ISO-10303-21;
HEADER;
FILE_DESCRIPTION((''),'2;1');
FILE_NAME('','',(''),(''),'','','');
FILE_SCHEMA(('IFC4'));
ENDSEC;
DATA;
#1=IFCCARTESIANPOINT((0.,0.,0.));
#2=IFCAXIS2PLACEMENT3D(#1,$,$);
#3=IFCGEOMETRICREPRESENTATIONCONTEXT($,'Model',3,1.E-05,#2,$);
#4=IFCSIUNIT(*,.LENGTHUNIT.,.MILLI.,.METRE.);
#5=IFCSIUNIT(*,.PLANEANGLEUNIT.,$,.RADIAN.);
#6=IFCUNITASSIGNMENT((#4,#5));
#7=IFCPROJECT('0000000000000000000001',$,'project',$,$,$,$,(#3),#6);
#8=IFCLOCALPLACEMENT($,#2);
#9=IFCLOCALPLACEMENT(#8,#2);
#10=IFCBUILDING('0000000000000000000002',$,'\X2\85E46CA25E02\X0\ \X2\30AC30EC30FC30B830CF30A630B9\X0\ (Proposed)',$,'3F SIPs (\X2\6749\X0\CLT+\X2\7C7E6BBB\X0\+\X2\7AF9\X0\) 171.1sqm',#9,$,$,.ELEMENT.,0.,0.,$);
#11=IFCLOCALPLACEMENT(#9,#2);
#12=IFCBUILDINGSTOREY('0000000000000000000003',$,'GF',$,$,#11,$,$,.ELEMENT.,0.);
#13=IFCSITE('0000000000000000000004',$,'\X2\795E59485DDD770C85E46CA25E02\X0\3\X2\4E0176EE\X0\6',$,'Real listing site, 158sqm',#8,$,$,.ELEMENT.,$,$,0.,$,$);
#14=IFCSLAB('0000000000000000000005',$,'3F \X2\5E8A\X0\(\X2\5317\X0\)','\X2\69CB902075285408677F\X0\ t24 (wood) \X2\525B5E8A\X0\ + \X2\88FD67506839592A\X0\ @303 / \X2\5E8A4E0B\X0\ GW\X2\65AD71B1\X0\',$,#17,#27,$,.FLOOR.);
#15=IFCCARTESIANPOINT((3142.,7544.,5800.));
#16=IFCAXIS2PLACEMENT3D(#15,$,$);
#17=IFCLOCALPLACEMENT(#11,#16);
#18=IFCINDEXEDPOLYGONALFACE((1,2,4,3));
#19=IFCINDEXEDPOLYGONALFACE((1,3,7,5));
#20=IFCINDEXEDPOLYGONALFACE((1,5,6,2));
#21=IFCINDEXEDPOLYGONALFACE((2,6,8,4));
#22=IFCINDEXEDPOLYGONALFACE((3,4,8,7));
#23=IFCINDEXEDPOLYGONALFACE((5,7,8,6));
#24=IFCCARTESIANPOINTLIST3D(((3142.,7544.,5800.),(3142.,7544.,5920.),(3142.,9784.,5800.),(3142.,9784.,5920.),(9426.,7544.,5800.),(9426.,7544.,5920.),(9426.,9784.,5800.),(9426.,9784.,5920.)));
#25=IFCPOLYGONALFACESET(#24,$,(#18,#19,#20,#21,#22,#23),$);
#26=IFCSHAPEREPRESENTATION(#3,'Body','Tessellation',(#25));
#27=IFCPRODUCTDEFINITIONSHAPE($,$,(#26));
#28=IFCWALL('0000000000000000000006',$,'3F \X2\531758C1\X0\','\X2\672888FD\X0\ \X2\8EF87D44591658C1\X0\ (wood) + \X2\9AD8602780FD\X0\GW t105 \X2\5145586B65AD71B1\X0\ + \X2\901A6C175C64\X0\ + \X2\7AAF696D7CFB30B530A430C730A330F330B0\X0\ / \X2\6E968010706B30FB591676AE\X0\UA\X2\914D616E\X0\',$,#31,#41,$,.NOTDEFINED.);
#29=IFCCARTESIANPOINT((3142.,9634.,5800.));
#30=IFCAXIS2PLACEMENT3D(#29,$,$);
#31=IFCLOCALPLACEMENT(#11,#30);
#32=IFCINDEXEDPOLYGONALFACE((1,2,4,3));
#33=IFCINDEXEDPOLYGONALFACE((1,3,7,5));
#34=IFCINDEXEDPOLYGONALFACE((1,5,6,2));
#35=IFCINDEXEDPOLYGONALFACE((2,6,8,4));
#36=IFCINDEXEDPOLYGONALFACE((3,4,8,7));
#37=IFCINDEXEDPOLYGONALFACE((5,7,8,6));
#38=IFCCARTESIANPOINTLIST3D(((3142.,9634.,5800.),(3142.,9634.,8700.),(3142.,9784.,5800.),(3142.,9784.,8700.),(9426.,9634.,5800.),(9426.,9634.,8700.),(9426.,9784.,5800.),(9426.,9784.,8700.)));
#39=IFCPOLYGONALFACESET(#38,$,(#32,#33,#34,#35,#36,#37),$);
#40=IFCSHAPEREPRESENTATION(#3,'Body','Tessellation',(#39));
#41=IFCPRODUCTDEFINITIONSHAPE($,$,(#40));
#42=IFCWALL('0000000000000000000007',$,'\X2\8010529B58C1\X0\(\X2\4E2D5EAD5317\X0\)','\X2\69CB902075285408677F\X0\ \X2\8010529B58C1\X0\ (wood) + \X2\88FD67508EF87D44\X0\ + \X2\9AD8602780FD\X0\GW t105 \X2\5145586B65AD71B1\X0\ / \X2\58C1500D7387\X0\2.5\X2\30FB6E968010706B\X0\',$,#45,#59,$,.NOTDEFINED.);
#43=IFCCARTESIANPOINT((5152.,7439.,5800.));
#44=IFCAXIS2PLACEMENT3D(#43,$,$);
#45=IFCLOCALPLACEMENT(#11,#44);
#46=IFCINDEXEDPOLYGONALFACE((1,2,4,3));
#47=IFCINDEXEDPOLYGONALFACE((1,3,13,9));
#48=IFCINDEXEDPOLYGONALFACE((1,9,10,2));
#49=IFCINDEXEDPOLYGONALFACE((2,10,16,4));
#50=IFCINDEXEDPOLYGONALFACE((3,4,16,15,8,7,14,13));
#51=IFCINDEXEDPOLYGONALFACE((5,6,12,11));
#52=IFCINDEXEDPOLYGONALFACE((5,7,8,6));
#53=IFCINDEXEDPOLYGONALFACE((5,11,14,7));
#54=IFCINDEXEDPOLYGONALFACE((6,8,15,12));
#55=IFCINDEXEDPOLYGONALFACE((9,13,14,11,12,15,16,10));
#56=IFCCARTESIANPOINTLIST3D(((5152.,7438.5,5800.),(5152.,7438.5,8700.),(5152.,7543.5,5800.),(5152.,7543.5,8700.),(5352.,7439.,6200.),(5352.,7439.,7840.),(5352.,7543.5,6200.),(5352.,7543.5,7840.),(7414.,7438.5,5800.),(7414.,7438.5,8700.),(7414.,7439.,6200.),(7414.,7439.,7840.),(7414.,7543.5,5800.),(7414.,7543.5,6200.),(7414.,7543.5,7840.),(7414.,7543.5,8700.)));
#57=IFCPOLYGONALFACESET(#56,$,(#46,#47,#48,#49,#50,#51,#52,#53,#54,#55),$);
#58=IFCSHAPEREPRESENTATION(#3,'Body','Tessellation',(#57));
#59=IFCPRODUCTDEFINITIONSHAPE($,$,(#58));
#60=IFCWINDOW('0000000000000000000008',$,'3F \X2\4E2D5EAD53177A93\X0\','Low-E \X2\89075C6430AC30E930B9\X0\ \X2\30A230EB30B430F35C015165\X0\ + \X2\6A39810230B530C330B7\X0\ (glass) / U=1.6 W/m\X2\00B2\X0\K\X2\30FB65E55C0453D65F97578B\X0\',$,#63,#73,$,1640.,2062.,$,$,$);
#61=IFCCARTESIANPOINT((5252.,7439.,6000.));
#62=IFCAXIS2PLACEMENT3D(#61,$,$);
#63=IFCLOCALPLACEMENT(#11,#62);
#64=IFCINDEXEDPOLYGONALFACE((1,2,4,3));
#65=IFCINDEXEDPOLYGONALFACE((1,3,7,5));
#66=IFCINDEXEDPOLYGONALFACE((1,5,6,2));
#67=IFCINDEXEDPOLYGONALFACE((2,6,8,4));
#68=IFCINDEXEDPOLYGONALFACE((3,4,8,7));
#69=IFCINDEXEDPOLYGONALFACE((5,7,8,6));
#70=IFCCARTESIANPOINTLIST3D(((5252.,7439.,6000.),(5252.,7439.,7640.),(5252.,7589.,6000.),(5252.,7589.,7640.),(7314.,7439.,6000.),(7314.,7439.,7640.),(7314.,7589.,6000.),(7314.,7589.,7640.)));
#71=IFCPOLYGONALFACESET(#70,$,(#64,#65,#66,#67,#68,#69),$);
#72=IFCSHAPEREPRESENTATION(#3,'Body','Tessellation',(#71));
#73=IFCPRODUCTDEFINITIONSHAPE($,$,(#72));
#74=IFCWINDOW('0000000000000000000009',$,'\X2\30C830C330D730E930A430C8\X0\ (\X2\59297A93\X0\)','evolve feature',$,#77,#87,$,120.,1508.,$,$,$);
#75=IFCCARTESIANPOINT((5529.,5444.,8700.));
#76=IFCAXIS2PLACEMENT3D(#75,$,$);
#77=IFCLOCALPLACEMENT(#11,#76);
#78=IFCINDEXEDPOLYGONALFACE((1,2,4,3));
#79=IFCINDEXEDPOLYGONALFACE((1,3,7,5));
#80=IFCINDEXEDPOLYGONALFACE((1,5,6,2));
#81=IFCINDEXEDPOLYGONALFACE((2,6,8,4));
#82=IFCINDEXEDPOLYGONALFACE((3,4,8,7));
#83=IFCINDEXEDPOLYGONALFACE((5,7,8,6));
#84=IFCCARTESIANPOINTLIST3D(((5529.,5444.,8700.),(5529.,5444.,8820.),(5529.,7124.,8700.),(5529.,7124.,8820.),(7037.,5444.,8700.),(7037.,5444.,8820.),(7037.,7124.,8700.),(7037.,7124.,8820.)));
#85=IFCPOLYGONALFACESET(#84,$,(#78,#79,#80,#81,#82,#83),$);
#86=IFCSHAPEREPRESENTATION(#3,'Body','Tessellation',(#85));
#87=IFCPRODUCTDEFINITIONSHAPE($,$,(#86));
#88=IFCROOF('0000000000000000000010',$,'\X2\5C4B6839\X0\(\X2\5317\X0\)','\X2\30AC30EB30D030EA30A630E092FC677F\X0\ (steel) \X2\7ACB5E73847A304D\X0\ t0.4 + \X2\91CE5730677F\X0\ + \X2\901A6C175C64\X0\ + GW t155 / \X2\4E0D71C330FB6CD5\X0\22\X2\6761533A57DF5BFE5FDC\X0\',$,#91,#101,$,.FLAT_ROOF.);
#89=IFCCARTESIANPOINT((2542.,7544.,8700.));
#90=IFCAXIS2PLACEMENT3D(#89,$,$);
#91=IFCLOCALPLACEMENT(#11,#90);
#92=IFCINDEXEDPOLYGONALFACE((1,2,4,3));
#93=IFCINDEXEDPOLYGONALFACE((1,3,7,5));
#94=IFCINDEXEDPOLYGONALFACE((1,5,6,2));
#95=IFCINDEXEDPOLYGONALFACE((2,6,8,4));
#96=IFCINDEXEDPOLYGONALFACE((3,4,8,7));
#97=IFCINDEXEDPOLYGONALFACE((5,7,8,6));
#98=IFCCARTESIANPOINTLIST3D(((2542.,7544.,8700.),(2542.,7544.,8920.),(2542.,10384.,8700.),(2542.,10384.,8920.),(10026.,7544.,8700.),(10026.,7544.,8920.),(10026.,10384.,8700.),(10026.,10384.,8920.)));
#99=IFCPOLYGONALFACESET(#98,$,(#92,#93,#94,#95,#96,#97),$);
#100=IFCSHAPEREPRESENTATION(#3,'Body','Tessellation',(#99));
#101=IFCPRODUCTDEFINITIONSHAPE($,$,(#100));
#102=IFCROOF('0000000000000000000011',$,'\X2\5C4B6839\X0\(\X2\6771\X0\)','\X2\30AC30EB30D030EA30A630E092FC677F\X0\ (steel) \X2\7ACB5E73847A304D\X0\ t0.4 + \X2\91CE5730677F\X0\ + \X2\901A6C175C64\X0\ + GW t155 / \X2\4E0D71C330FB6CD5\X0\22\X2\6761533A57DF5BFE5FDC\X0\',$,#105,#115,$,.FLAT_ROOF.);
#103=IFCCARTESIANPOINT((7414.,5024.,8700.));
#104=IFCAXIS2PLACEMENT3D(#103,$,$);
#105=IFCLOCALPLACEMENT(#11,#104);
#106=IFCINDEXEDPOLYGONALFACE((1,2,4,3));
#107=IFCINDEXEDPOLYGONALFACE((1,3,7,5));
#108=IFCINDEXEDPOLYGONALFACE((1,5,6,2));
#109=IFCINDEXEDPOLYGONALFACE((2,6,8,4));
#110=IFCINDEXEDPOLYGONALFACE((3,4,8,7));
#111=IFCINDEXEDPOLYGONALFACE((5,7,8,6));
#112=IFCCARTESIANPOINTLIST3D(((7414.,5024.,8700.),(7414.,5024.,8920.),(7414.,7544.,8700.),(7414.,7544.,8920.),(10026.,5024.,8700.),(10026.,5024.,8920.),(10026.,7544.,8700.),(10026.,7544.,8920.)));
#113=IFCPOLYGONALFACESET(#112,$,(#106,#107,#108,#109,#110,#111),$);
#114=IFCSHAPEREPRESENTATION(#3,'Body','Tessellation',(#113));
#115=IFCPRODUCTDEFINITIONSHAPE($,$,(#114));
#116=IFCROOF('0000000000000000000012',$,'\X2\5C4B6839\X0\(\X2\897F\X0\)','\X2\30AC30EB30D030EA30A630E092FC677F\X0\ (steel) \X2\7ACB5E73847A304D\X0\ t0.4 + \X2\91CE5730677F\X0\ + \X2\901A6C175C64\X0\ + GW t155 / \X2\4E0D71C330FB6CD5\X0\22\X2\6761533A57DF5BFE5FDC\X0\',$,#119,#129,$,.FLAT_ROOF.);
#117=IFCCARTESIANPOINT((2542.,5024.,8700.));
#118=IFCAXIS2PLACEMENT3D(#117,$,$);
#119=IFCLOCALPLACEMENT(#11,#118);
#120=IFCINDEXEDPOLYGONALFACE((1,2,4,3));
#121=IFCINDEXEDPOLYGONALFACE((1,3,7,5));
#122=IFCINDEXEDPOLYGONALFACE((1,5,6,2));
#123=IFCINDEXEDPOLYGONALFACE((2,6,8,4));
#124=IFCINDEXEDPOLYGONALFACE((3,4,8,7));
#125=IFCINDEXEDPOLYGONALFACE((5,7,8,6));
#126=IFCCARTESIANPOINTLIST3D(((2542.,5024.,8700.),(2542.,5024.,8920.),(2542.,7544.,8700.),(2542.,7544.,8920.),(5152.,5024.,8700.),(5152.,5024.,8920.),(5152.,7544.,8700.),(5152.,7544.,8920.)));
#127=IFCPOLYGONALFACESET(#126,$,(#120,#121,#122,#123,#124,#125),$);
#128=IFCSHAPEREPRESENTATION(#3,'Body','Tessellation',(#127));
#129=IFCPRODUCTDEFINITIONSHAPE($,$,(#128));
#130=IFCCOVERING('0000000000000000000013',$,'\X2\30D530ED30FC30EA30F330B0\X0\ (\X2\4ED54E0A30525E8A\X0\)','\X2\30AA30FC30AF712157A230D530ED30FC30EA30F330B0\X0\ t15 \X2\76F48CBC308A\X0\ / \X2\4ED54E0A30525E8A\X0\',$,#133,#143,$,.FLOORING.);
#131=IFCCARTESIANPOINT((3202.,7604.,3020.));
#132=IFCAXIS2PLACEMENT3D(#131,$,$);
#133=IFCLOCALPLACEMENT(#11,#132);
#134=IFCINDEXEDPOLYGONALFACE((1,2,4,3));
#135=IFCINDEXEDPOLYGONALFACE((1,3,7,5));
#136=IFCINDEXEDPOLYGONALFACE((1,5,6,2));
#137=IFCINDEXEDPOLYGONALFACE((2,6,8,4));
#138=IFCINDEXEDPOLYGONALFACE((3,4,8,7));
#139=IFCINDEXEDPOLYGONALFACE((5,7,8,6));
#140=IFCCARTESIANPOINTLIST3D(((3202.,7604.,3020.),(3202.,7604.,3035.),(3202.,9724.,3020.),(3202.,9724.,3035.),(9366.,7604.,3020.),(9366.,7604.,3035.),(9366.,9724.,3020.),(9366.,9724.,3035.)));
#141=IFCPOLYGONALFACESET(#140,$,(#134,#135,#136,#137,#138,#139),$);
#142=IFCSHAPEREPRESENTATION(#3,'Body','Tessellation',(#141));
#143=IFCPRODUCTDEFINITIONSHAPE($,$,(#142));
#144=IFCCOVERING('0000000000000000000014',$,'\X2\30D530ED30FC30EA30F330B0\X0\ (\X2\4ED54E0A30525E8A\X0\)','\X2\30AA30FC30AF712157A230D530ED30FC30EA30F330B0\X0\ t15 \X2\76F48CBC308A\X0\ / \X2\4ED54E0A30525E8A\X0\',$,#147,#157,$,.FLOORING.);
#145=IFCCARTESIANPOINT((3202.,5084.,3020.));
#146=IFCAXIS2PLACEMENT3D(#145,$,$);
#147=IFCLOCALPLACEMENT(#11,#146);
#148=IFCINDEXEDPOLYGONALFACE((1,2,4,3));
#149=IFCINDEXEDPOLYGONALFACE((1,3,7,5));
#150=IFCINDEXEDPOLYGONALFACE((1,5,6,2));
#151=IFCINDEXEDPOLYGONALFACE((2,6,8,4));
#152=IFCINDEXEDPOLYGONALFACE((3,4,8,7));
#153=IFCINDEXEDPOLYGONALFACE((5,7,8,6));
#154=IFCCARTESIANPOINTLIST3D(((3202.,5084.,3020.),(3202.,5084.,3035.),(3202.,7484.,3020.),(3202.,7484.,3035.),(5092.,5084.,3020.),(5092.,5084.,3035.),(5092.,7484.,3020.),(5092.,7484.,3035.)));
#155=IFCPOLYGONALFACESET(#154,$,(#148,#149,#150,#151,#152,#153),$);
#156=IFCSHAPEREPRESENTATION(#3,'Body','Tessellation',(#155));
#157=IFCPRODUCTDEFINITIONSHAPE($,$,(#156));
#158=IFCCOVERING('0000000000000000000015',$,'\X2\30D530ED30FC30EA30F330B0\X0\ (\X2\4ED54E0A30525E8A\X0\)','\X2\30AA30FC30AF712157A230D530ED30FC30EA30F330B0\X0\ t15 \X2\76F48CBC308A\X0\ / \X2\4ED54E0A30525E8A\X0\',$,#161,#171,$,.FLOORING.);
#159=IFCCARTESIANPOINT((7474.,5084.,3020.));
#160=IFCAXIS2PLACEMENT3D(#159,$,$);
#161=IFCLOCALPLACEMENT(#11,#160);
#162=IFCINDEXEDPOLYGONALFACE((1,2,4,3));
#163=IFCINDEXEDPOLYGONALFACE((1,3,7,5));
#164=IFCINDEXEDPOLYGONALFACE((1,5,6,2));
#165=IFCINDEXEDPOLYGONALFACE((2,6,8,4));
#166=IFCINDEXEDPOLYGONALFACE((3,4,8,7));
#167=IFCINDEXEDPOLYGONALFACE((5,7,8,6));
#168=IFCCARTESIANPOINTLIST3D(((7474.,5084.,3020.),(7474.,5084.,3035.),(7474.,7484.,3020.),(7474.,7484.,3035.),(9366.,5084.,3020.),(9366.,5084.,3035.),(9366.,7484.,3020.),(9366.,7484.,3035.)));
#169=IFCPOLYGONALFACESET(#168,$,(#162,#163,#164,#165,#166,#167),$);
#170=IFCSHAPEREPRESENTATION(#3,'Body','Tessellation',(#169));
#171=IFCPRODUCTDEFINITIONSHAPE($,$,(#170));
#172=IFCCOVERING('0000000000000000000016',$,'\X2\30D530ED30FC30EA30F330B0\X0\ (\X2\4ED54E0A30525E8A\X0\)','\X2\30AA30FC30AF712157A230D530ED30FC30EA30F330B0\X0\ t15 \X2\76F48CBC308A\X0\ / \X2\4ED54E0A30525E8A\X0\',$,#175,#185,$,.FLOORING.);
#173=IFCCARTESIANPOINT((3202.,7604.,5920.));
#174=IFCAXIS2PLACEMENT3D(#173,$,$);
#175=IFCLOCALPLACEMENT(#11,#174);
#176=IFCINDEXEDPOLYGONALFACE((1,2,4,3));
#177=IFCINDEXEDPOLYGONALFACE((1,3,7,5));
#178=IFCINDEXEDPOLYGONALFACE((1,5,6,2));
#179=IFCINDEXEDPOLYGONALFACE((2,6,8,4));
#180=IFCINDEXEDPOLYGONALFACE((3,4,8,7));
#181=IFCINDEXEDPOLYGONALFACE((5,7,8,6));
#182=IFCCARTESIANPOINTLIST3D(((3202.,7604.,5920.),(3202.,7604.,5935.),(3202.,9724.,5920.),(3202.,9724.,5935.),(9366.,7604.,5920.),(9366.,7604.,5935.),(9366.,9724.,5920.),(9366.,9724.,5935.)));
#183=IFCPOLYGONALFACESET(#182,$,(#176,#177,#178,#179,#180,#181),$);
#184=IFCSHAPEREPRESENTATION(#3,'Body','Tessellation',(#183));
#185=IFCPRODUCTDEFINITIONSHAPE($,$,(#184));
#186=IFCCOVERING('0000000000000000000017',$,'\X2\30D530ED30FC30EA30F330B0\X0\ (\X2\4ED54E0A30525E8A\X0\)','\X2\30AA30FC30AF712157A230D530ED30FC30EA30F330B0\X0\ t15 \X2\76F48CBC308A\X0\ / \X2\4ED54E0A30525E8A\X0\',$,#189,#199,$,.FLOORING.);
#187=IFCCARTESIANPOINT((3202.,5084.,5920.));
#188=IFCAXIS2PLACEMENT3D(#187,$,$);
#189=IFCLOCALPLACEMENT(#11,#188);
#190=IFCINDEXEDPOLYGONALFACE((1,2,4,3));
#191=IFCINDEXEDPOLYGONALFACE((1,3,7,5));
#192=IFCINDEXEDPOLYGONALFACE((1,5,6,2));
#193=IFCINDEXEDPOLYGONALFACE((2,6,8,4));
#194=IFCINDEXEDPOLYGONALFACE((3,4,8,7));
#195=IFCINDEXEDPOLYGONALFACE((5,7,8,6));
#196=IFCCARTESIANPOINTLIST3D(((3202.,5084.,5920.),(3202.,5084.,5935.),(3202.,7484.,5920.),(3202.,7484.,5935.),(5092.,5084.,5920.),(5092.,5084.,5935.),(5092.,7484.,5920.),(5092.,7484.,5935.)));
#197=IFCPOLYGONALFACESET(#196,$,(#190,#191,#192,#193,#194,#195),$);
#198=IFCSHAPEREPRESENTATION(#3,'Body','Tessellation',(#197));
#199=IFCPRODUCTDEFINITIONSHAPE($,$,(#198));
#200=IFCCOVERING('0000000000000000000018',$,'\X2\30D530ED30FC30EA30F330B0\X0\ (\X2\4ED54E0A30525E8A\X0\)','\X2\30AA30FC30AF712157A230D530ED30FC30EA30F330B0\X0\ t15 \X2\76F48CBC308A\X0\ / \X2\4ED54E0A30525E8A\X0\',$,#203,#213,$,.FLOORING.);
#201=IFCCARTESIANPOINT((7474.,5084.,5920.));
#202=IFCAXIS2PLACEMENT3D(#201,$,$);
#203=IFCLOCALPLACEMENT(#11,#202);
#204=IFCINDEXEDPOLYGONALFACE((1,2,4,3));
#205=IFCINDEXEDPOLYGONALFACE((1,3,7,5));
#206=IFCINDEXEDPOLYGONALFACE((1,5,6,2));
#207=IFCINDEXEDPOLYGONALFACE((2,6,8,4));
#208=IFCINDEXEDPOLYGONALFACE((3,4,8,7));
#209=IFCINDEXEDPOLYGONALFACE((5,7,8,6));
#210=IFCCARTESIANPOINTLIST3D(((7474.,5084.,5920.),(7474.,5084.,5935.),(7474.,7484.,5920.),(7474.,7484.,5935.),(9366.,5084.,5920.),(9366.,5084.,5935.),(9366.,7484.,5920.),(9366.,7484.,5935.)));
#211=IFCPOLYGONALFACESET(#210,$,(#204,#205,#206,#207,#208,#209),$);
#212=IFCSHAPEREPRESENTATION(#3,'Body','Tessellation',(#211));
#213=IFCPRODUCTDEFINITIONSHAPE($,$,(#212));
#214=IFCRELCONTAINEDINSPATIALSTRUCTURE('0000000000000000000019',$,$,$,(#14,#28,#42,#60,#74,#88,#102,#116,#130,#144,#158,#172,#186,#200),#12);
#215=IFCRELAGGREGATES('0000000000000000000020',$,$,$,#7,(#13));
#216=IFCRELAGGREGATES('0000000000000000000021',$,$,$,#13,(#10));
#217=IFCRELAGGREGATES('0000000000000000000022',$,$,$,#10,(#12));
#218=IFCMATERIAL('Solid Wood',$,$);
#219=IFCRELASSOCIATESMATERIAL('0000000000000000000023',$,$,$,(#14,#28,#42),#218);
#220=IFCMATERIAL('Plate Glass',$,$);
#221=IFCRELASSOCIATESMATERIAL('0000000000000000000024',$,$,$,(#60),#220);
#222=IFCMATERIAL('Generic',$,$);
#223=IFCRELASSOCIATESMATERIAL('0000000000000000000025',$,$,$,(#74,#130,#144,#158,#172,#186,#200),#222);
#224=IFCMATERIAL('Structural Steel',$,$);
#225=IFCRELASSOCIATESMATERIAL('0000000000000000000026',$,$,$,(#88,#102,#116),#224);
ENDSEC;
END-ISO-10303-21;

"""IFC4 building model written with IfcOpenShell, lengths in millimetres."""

from ifc_helpers import new_model, si_unit, frame, frame_2d, origin, place, context, project, spatial, rectangle, extrude, material, element, fill, save


model = new_model("IFC4")

# Units and contexts
model_context = context("Model", 3, precision=1e-05, world=origin())
ifc_project = project(units=[si_unit("LENGTHUNIT", "METRE", prefix="MILLI"), si_unit("PLANEANGLEUNIT", "RADIAN")], contexts=[model_context])

# Site, building, storey
site_placement = place(None, origin())
site = spatial("IfcSite", under=ifc_project, at=site_placement, Name="神奈川県藤沢市3丁目6", ObjectType="Real listing site, 158sqm", CompositionType="ELEMENT", RefElevation=0.0)
building_placement = place(site_placement, origin())
building = spatial("IfcBuilding", under=site, at=building_placement, Name="藤沢市 ガレージハウス (Proposed)", ObjectType="3F SIPs (杉CLT+籾殻+竹) 171.1sqm", CompositionType="ELEMENT", ElevationOfRefHeight=0.0, ElevationOfTerrain=0.0)
storey_placement = place(building_placement, origin())
storey = spatial("IfcBuildingStorey", under=building, at=storey_placement, Name="GF", CompositionType="ELEMENT", Elevation=0.0)

# Slab
ifc_material_1 = material(Name="Solid Wood")
slab_placement = place(storey_placement, frame((3142.0, 7544.0, 5800.0)))
element("IfcSlab", 1, at=slab_placement, inside=storey, material=ifc_material_1, Name="3F 床(北)", Description="構造用合板 t24 (wood) 剛床 + 製材根太 @303 / 床下 GW断熱", PredefinedType="FLOOR", context=model_context, shape_type="SweptSolid", body=[
    extrude(rectangle(XDim=6284.0, YDim=2240.0, at=frame_2d((3142.0, 1120.0))), frame((3142.0, 7544.0, 5800.0)), (0.0, 0.0, 1.0), 120.0),
])

# Wall
wall_1_placement = place(storey_placement, frame((3142.0, 9634.0, 5800.0)))
element("IfcWall", 2, at=wall_1_placement, inside=storey, material=ifc_material_1, Name="3F 北壁", Description="木製 軸組外壁 (wood) + 高性能GW t105 充填断熱 + 通気層 + 窯業系サイディング / 準耐火・外皮UA配慮", PredefinedType="NOTDEFINED", context=model_context, shape_type="SweptSolid", body=[
    extrude(rectangle(XDim=6284.0, YDim=150.0, at=frame_2d((3142.0, 75.0))), frame((3142.0, 9634.0, 5800.0)), (0.0, 0.0, 1.0), 2900.0),
])

# Wall, opening, window
wall_2_placement = place(storey_placement, frame((5152.0, 7439.0, 5800.0)))
wall_2 = element("IfcWall", 3, at=wall_2_placement, inside=storey, material=ifc_material_1, Name="耐力壁(中庭北)", Description="構造用合板 耐力壁 (wood) + 製材軸組 + 高性能GW t105 充填断熱 / 壁倍率2.5・準耐火", PredefinedType="NOTDEFINED", context=model_context, shape_type="SweptSolid", body=[
    extrude(rectangle(XDim=2262.0, YDim=105.0, at=frame_2d((1131.0, 52.0))), frame((5152.0, 7439.0, 5800.0)), (0.0, 0.0, 1.0), 2900.0),
])
opening_placement = place(storey_placement, frame((5252.0, 7439.0, 6000.0)))
opening = element("IfcOpeningElement", 4, at=opening_placement, cuts=wall_2, PredefinedType="NOTDEFINED", context=model_context, shape_type="SweptSolid", body=[
    extrude(rectangle(XDim=2062.0, YDim=150.0, at=frame_2d((1031.0, 75.0))), frame((5252.0, 7439.0, 6000.0)), (0.0, 0.0, 1.0), 1640.0),
])
ifc_material_2 = material(Name="Plate Glass")
window_1_placement = place(storey_placement, frame((5252.0, 7439.0, 6000.0)))
window_1 = element("IfcWindow", 5, at=window_1_placement, inside=storey, material=ifc_material_2, Name="3F 中庭北窓", Description="Low-E 複層ガラス アルゴン封入 + 樹脂サッシ (glass) / U=1.6 W/m²K・日射取得型", OverallHeight=1640.0, OverallWidth=2062.0, context=model_context, shape_type="SweptSolid", body=[
    extrude(rectangle(XDim=2062.0, YDim=150.0, at=frame_2d((1031.0, 75.0))), frame((5252.0, 7439.0, 6000.0)), (0.0, 0.0, 1.0), 1640.0),
])
fill(opening, window_1)

# Window
ifc_material_3 = material(Name="Generic")
window_2_placement = place(storey_placement, frame((5529.0, 5444.0, 8700.0)))
element("IfcWindow", 6, at=window_2_placement, inside=storey, material=ifc_material_3, Name="トップライト (天窓)", Description="evolve feature", OverallHeight=120.0, OverallWidth=1508.0, context=model_context, shape_type="SweptSolid", body=[
    extrude(rectangle(XDim=1508.0, YDim=1680.0, at=frame_2d((754.0, 840.0))), frame((5529.0, 5444.0, 8700.0)), (0.0, 0.0, 1.0), 120.0),
])

# Roofs
ifc_material_4 = material(Name="Structural Steel")
roof_1_placement = place(storey_placement, frame((2542.0, 7544.0, 8700.0)))
element("IfcRoof", 7, at=roof_1_placement, inside=storey, material=ifc_material_4, Name="屋根(北)", Description="ガルバリウム鋼板 (steel) 立平葺き t0.4 + 野地板 + 通気層 + GW t155 / 不燃・法22条区域対応", PredefinedType="FLAT_ROOF", context=model_context, shape_type="SweptSolid", body=[
    extrude(rectangle(XDim=7484.0, YDim=2840.0, at=frame_2d((3742.0, 1420.0))), frame((2542.0, 7544.0, 8700.0)), (0.0, 0.0, 1.0), 220.0),
])
roof_2_placement = place(storey_placement, frame((7414.0, 5024.0, 8700.0)))
element("IfcRoof", 8, at=roof_2_placement, inside=storey, material=ifc_material_4, Name="屋根(東)", Description="ガルバリウム鋼板 (steel) 立平葺き t0.4 + 野地板 + 通気層 + GW t155 / 不燃・法22条区域対応", PredefinedType="FLAT_ROOF", context=model_context, shape_type="SweptSolid", body=[
    extrude(rectangle(XDim=2612.0, YDim=2520.0, at=frame_2d((1306.0, 1260.0))), frame((7414.0, 5024.0, 8700.0)), (0.0, 0.0, 1.0), 220.0),
])
roof_3_placement = place(storey_placement, frame((2542.0, 5024.0, 8700.0)))
element("IfcRoof", 9, at=roof_3_placement, inside=storey, material=ifc_material_4, Name="屋根(西)", Description="ガルバリウム鋼板 (steel) 立平葺き t0.4 + 野地板 + 通気層 + GW t155 / 不燃・法22条区域対応", PredefinedType="FLAT_ROOF", context=model_context, shape_type="SweptSolid", body=[
    extrude(rectangle(XDim=2610.0, YDim=2520.0, at=frame_2d((1305.0, 1260.0))), frame((2542.0, 5024.0, 8700.0)), (0.0, 0.0, 1.0), 220.0),
])

# Coverings
covering_1_placement = place(storey_placement, frame((3202.0, 7604.0, 3020.0)))
element("IfcCovering", 10, at=covering_1_placement, inside=storey, material=ifc_material_3, Name="フローリング (仕上げ床)", Description="オーク無垢フローリング t15 直貼り / 仕上げ床", PredefinedType="FLOORING", context=model_context, shape_type="SweptSolid", body=[
    extrude(rectangle(XDim=6164.0, YDim=2120.0, at=frame_2d((3082.0, 1060.0))), frame((3202.0, 7604.0, 3020.0)), (0.0, 0.0, 1.0), 15.0),
])
covering_2_placement = place(storey_placement, frame((3202.0, 5084.0, 3020.0)))
element("IfcCovering", 11, at=covering_2_placement, inside=storey, material=ifc_material_3, Name="フローリング (仕上げ床)", Description="オーク無垢フローリング t15 直貼り / 仕上げ床", PredefinedType="FLOORING", context=model_context, shape_type="SweptSolid", body=[
    extrude(rectangle(XDim=1890.0, YDim=2400.0, at=frame_2d((945.0, 1200.0))), frame((3202.0, 5084.0, 3020.0)), (0.0, 0.0, 1.0), 15.0),
])
covering_3_placement = place(storey_placement, frame((7474.0, 5084.0, 3020.0)))
element("IfcCovering", 12, at=covering_3_placement, inside=storey, material=ifc_material_3, Name="フローリング (仕上げ床)", Description="オーク無垢フローリング t15 直貼り / 仕上げ床", PredefinedType="FLOORING", context=model_context, shape_type="SweptSolid", body=[
    extrude(rectangle(XDim=1892.0, YDim=2400.0, at=frame_2d((946.0, 1200.0))), frame((7474.0, 5084.0, 3020.0)), (0.0, 0.0, 1.0), 15.0),
])
covering_4_placement = place(storey_placement, frame((3202.0, 7604.0, 5920.0)))
element("IfcCovering", 13, at=covering_4_placement, inside=storey, material=ifc_material_3, Name="フローリング (仕上げ床)", Description="オーク無垢フローリング t15 直貼り / 仕上げ床", PredefinedType="FLOORING", context=model_context, shape_type="SweptSolid", body=[
    extrude(rectangle(XDim=6164.0, YDim=2120.0, at=frame_2d((3082.0, 1060.0))), frame((3202.0, 7604.0, 5920.0)), (0.0, 0.0, 1.0), 15.0),
])
covering_5_placement = place(storey_placement, frame((3202.0, 5084.0, 5920.0)))
element("IfcCovering", 14, at=covering_5_placement, inside=storey, material=ifc_material_3, Name="フローリング (仕上げ床)", Description="オーク無垢フローリング t15 直貼り / 仕上げ床", PredefinedType="FLOORING", context=model_context, shape_type="SweptSolid", body=[
    extrude(rectangle(XDim=1890.0, YDim=2400.0, at=frame_2d((945.0, 1200.0))), frame((3202.0, 5084.0, 5920.0)), (0.0, 0.0, 1.0), 15.0),
])
covering_6_placement = place(storey_placement, frame((7474.0, 5084.0, 5920.0)))
element("IfcCovering", 15, at=covering_6_placement, inside=storey, material=ifc_material_3, Name="フローリング (仕上げ床)", Description="オーク無垢フローリング t15 直貼り / 仕上げ床", PredefinedType="FLOORING", context=model_context, shape_type="SweptSolid", body=[
    extrude(rectangle(XDim=1892.0, YDim=2400.0, at=frame_2d((946.0, 1200.0))), frame((7474.0, 5084.0, 5920.0)), (0.0, 0.0, 1.0), 15.0),
])

save(model, "model.ifc")
